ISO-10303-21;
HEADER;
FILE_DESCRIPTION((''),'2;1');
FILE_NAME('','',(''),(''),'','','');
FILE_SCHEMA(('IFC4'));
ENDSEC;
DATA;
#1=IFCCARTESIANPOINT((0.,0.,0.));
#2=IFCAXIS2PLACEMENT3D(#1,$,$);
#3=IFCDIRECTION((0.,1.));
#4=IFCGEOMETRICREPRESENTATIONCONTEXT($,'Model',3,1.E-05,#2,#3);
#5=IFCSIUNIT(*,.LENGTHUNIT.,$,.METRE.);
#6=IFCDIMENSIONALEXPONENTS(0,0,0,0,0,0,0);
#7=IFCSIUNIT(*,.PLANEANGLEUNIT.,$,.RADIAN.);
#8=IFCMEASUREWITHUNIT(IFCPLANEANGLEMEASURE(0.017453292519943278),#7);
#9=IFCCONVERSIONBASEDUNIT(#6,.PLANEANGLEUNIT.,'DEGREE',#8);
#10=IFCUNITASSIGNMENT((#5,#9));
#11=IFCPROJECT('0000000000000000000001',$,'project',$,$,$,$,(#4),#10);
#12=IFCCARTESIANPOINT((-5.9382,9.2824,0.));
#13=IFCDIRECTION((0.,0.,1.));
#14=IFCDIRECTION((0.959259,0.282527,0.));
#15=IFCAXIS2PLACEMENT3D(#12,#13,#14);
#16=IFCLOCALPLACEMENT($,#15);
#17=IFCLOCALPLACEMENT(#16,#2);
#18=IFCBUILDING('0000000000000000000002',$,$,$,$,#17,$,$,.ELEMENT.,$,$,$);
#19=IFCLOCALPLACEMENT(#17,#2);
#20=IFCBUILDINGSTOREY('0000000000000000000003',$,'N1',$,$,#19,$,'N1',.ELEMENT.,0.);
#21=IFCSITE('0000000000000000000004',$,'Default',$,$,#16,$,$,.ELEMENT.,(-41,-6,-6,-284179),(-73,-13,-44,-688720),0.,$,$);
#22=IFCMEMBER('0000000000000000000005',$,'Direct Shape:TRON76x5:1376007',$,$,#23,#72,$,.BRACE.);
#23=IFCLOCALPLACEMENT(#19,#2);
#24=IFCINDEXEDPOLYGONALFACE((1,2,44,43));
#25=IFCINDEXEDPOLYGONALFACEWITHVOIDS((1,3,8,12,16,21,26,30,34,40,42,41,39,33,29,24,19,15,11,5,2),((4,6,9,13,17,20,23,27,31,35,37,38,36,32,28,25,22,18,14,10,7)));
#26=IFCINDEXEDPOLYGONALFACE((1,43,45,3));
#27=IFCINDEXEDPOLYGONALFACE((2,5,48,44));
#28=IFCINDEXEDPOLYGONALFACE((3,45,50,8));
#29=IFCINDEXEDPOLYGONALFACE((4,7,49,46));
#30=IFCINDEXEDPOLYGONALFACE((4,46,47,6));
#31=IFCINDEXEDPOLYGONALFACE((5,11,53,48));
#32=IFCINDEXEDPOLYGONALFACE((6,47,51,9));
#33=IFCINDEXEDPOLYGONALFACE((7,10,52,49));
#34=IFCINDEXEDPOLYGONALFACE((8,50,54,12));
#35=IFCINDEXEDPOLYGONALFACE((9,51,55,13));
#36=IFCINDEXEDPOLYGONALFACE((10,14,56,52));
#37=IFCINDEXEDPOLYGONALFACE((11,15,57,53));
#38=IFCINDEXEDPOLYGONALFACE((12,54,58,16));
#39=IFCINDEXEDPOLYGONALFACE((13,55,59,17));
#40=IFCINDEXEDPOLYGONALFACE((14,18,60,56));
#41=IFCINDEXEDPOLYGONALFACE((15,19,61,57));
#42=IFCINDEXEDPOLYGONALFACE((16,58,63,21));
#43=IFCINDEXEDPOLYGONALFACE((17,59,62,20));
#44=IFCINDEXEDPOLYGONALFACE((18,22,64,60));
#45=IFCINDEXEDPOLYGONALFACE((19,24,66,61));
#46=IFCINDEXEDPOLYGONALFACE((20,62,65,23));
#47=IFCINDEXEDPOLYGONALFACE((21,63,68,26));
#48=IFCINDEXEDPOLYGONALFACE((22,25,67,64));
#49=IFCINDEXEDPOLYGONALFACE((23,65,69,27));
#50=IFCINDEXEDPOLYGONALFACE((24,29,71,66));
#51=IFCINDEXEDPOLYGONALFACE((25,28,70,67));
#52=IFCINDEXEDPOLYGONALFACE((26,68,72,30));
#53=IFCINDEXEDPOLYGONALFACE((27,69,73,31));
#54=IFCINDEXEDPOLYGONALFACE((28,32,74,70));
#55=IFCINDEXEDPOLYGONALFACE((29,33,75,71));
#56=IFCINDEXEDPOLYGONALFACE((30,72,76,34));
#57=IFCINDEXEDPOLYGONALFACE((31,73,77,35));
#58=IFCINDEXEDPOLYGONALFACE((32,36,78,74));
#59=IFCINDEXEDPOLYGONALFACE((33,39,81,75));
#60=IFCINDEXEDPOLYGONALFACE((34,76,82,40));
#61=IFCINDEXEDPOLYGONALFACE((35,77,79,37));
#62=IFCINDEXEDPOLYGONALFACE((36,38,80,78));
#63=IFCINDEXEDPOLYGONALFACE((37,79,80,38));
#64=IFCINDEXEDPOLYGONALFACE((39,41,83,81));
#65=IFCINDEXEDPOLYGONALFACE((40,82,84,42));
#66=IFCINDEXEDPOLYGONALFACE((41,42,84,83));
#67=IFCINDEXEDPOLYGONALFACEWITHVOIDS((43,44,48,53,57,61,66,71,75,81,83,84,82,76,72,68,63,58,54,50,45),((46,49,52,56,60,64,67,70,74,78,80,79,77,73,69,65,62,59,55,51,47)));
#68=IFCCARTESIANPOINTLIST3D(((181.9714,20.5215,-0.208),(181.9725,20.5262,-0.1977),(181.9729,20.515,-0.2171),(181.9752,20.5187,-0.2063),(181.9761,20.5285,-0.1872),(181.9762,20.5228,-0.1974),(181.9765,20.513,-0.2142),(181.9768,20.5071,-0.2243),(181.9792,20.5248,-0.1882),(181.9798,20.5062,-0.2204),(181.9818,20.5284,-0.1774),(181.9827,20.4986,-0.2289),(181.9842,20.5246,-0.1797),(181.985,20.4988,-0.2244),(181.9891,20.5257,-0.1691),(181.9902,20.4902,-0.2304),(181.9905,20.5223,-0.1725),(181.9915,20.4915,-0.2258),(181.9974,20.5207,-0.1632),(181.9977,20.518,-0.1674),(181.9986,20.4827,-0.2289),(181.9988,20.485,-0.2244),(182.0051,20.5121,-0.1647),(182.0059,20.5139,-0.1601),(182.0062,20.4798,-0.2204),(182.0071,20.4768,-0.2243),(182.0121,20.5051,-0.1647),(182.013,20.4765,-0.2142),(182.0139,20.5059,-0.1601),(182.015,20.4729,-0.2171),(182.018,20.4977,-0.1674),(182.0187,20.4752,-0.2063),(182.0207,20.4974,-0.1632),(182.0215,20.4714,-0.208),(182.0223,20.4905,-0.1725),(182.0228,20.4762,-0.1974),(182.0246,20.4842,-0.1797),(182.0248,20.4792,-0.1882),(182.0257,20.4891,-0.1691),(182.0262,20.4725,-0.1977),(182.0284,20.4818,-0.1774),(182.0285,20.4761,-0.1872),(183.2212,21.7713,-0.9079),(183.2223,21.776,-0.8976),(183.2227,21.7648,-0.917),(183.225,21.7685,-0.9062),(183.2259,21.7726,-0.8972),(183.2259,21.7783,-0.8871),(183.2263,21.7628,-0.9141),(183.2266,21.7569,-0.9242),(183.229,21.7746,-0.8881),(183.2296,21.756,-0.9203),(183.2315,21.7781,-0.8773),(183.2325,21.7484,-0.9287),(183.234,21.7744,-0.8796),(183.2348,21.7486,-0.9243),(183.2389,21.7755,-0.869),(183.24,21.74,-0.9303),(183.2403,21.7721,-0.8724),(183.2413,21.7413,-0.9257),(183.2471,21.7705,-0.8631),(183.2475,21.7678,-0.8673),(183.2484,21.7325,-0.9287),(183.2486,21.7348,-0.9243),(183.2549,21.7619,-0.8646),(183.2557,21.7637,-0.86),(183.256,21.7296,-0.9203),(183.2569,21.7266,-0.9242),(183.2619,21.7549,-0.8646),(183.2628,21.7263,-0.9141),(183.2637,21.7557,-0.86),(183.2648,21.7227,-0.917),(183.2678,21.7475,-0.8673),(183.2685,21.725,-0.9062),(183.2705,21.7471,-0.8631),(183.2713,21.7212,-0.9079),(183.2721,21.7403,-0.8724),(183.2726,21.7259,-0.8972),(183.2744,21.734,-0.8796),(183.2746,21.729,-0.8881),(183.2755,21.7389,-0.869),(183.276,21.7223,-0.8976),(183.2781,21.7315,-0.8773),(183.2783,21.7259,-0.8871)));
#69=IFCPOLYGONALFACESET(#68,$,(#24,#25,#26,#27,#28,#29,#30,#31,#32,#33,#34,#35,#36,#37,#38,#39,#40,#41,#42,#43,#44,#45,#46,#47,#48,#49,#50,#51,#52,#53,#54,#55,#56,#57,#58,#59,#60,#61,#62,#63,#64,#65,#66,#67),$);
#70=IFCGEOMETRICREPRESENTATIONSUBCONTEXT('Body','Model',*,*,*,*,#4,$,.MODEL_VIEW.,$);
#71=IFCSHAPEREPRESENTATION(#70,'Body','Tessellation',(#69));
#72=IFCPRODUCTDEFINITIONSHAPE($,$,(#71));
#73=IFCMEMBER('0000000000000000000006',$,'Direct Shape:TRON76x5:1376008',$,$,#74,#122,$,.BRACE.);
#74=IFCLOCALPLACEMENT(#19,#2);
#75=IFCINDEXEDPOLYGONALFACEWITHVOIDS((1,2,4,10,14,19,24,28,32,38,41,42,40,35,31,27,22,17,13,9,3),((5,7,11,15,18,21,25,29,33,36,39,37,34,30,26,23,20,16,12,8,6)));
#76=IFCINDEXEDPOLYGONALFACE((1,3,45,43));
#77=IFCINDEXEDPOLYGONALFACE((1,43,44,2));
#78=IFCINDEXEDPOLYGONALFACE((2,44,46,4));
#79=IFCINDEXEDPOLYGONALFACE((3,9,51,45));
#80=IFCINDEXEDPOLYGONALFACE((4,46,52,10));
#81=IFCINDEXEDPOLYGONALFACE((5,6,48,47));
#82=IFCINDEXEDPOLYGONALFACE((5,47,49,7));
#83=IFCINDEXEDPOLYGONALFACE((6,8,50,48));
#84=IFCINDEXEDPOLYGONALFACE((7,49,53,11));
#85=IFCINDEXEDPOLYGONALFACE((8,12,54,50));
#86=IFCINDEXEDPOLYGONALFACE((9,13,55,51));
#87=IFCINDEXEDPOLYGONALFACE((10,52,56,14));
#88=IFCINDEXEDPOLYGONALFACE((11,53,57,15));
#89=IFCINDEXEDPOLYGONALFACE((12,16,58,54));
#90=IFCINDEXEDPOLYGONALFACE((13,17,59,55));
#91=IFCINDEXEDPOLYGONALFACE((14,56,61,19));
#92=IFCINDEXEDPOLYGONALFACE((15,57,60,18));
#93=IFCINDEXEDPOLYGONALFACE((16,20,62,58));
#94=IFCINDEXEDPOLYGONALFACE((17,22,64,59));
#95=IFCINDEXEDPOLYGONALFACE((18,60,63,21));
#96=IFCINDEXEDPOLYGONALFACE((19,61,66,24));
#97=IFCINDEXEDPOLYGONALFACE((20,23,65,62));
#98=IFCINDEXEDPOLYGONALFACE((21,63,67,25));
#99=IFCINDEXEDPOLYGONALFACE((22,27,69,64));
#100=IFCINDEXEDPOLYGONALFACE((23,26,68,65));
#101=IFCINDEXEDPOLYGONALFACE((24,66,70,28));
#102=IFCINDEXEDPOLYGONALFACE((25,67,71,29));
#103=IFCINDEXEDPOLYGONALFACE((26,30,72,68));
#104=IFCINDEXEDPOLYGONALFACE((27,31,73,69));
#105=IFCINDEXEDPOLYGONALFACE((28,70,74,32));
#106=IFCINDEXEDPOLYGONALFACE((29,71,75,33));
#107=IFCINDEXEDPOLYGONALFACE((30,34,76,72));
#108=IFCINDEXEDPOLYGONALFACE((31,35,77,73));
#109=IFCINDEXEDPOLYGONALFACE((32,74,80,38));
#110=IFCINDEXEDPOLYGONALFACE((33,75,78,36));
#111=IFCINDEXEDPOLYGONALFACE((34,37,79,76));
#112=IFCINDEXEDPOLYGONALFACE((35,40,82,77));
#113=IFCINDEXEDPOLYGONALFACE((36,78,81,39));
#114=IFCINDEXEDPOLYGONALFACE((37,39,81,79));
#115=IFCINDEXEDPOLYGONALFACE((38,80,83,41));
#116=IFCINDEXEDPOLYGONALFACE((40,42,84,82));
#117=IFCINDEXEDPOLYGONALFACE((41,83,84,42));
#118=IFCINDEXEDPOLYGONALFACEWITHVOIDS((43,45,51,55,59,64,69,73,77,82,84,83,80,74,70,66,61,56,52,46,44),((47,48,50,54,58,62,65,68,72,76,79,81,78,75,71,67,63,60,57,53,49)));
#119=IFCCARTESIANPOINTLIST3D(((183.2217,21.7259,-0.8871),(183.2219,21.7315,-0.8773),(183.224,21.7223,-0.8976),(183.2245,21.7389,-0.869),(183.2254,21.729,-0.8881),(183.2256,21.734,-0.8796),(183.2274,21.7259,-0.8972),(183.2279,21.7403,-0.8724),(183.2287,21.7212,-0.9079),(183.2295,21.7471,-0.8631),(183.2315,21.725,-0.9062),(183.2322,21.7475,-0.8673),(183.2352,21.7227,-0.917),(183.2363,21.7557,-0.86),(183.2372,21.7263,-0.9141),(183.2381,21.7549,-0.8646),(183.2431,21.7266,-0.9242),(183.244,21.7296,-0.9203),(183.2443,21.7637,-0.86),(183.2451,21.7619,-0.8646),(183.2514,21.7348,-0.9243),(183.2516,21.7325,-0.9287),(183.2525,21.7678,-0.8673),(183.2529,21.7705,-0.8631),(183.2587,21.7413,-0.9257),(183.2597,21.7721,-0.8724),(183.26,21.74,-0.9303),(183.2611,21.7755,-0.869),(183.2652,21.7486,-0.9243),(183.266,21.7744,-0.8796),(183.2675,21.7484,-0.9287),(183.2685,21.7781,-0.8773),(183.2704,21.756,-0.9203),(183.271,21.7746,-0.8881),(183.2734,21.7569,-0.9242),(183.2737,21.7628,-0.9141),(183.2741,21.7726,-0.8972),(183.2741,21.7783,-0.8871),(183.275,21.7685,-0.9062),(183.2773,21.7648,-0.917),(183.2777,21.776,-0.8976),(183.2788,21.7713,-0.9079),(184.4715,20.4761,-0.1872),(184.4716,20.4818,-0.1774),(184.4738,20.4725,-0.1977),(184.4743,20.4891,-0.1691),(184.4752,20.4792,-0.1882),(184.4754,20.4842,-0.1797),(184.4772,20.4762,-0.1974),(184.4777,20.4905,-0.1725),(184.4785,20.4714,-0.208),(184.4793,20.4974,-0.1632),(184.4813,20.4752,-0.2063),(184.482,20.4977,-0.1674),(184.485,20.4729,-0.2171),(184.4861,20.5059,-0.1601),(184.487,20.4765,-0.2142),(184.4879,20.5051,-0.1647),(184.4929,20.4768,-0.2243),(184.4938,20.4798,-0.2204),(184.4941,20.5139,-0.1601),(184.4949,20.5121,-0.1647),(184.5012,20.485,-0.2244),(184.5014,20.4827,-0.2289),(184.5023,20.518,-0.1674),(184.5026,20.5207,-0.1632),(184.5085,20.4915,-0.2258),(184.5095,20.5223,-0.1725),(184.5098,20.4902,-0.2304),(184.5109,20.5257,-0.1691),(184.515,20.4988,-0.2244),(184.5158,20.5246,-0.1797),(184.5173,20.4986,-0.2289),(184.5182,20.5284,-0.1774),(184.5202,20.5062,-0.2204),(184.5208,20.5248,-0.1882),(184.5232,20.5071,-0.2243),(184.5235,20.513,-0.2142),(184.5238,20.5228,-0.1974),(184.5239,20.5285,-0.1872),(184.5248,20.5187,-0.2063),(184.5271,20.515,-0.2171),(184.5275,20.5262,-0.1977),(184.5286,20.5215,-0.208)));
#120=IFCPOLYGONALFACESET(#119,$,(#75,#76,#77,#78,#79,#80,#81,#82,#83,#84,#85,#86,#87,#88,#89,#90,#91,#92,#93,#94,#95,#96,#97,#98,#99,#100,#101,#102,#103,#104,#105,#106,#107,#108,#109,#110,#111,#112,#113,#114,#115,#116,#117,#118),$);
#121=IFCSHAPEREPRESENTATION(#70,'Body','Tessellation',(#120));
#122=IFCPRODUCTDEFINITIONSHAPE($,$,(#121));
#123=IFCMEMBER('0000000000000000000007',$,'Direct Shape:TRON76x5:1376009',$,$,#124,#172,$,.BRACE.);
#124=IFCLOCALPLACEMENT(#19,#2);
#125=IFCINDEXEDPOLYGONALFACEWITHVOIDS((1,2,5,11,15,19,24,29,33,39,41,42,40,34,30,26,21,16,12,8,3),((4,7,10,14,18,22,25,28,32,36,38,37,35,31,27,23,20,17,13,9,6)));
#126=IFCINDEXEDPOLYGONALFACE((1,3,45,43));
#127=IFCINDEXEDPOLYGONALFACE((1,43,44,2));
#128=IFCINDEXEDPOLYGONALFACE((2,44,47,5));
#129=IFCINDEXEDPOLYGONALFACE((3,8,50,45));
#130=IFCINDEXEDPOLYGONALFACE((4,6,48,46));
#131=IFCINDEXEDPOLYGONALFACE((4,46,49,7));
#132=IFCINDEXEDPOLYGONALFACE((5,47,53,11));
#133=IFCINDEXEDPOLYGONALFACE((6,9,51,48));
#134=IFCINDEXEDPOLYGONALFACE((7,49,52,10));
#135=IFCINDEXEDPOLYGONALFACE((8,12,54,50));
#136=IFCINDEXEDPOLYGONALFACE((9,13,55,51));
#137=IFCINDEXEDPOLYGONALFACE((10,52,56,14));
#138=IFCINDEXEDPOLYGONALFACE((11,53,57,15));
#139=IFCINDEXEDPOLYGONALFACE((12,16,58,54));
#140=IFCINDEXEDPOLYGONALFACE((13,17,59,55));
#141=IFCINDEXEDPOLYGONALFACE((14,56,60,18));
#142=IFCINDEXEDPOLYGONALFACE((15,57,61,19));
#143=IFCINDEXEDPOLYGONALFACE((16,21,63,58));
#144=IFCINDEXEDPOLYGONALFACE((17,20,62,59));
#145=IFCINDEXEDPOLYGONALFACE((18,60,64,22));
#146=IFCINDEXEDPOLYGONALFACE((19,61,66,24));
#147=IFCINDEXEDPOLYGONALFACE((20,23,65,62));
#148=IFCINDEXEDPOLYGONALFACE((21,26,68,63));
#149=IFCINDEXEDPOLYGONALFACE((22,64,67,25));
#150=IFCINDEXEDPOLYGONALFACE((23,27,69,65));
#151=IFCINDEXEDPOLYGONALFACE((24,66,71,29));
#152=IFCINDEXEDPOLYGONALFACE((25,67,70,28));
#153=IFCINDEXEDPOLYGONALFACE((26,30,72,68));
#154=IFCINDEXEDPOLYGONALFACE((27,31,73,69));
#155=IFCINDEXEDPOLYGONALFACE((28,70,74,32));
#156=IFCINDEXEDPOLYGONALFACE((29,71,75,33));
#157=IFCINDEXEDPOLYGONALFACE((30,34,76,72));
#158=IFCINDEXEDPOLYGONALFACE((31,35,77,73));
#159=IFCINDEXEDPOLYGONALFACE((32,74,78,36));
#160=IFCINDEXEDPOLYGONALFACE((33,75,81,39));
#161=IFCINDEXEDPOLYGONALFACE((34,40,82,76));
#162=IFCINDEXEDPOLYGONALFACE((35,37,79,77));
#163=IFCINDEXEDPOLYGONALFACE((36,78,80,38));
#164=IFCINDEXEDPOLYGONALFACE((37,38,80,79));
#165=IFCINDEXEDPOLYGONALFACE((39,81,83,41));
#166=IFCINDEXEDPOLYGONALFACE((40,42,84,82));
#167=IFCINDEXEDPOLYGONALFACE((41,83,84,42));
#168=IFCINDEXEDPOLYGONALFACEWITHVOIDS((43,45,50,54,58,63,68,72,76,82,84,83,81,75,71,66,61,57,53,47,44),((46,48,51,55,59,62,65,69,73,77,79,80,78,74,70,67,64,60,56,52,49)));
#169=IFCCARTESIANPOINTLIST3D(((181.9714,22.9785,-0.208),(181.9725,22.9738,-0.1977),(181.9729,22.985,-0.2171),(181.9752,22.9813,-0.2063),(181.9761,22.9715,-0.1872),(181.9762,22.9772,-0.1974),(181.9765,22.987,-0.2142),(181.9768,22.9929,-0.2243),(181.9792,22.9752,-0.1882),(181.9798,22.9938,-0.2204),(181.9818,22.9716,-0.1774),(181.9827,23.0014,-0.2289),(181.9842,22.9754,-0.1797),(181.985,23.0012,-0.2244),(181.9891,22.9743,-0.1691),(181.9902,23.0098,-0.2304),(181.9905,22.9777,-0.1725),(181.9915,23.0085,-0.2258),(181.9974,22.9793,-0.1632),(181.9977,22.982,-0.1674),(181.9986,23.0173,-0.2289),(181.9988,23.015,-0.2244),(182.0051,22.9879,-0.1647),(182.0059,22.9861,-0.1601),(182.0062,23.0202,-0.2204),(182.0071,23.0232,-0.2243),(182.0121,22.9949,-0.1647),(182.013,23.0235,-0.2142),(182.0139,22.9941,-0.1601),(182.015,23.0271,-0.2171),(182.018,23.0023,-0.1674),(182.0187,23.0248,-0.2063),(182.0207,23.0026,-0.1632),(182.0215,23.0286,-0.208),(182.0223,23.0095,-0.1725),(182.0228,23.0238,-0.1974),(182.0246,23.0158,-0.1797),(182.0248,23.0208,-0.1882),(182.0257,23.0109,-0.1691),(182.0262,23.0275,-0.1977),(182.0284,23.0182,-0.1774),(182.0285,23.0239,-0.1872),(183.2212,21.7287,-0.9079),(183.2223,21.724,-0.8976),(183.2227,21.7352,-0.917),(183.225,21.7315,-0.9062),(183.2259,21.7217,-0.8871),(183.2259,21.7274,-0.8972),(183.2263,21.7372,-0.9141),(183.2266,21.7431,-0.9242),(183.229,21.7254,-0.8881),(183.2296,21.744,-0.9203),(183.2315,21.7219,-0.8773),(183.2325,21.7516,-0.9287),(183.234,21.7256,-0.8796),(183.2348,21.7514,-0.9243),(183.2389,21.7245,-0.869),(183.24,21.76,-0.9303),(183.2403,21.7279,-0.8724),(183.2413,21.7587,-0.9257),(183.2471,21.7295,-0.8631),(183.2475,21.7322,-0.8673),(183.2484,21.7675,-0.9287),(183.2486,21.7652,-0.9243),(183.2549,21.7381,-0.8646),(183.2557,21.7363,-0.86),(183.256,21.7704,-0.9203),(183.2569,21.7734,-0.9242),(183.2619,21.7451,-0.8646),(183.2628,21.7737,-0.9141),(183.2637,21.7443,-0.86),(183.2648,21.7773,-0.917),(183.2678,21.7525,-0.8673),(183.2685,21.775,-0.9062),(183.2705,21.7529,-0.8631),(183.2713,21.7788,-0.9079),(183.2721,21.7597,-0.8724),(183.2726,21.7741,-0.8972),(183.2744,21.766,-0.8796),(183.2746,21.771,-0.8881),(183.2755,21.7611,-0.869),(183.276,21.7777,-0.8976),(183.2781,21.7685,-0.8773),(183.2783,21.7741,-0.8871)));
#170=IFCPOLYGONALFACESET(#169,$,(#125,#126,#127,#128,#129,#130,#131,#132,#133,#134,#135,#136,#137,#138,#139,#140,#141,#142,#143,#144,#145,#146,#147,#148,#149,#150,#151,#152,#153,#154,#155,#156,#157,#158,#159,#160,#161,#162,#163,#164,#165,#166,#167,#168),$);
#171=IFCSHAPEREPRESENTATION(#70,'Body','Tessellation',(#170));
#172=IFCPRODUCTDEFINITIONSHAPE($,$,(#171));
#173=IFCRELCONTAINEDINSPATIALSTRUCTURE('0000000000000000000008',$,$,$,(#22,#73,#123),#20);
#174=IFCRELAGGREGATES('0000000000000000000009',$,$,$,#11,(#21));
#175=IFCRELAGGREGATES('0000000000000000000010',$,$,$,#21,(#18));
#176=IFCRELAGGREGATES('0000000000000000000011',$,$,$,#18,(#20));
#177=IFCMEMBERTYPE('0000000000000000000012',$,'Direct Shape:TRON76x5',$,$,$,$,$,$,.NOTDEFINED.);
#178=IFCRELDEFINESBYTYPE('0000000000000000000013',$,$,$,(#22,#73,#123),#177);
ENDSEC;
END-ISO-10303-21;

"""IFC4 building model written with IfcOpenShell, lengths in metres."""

from ifc_helpers import new_model, entity, si_unit, converted_unit, direction, frame, origin, origin_2d_with_axis, place, context, subcontext, project, spatial, hollow_circle, extrude, type_object, element, save


model = new_model("IFC4")

# Units and contexts
model_context = context("Model", 3, precision=1e-05, world=origin(), true_north=direction((0.0, 1.0)))
body_context = subcontext(model_context, "Body", "Model", "MODEL_VIEW")
ifc_project = project(units=[si_unit("LENGTHUNIT", "METRE"), converted_unit("PLANEANGLEUNIT", "DEGREE", entity("IfcPlaneAngleMeasure", 0.017453292519943278), si_unit("PLANEANGLEUNIT", "RADIAN"), dimensions=[0, 0, 0, 0, 0, 0, 0])], contexts=[model_context])

# Site, building, storey
site_placement = place(None, frame((-5.9382, 9.2824, 0.0), z_axis=(0.0, 0.0, 1.0), x_axis=(0.959259, 0.282527, 0.0)))
site = spatial("IfcSite", under=ifc_project, at=site_placement, Name="Default", CompositionType="ELEMENT", RefLatitude=(-41, -6, -6, -284179), RefLongitude=(-73, -13, -44, -688720), RefElevation=0.0)
building_placement = place(site_placement, origin())
building = spatial("IfcBuilding", under=site, at=building_placement, CompositionType="ELEMENT")
storey_placement = place(building_placement, origin())
storey = spatial("IfcBuildingStorey", under=building, at=storey_placement, Name="N1", LongName="N1", CompositionType="ELEMENT", Elevation=0.0)

# Members
member_type_1 = type_object("IfcMemberType", Name="Direct Shape:TRON76x5", PredefinedType="NOTDEFINED")
member_1_placement = place(storey_placement, origin())
element("IfcMember", 1, at=member_1_placement, inside=storey, type_object=member_type_1, Name="Direct Shape:TRON76x5:1376007", PredefinedType="BRACE", context=body_context, shape_type="SweptSolid", body=[
    extrude(hollow_circle(Radius=0.0381, WallThickness=0.005, at=origin_2d_with_axis()), frame((183.2499, 21.7499, -0.8949), z_axis=(-0.65744, -0.65744, 0.368166), x_axis=(-0.260333, -0.260333, -0.92976)), (0.0, 0.0, 1.0), 1.901),
])
member_2_placement = place(storey_placement, origin())
element("IfcMember", 2, at=member_2_placement, inside=storey, type_object=member_type_1, Name="Direct Shape:TRON76x5:1376008", PredefinedType="BRACE", context=body_context, shape_type="SweptSolid", body=[
    extrude(hollow_circle(Radius=0.0381, WallThickness=0.005, at=origin_2d_with_axis()), frame((183.2501, 21.7499, -0.8949), z_axis=(0.65744, -0.65744, 0.368166), x_axis=(0.260333, -0.260333, -0.92976)), (0.0, 0.0, 1.0), 1.901),
])
member_3_placement = place(storey_placement, origin())
element("IfcMember", 3, at=member_3_placement, inside=storey, type_object=member_type_1, Name="Direct Shape:TRON76x5:1376009", PredefinedType="BRACE", context=body_context, shape_type="SweptSolid", body=[
    extrude(hollow_circle(Radius=0.0381, WallThickness=0.005, at=origin_2d_with_axis()), frame((183.2499, 21.7501, -0.8949), z_axis=(-0.65744, 0.65744, 0.368166), x_axis=(-0.260333, 0.260333, -0.92976)), (0.0, 0.0, 1.0), 1.901),
])

save(model, "model.ifc")
